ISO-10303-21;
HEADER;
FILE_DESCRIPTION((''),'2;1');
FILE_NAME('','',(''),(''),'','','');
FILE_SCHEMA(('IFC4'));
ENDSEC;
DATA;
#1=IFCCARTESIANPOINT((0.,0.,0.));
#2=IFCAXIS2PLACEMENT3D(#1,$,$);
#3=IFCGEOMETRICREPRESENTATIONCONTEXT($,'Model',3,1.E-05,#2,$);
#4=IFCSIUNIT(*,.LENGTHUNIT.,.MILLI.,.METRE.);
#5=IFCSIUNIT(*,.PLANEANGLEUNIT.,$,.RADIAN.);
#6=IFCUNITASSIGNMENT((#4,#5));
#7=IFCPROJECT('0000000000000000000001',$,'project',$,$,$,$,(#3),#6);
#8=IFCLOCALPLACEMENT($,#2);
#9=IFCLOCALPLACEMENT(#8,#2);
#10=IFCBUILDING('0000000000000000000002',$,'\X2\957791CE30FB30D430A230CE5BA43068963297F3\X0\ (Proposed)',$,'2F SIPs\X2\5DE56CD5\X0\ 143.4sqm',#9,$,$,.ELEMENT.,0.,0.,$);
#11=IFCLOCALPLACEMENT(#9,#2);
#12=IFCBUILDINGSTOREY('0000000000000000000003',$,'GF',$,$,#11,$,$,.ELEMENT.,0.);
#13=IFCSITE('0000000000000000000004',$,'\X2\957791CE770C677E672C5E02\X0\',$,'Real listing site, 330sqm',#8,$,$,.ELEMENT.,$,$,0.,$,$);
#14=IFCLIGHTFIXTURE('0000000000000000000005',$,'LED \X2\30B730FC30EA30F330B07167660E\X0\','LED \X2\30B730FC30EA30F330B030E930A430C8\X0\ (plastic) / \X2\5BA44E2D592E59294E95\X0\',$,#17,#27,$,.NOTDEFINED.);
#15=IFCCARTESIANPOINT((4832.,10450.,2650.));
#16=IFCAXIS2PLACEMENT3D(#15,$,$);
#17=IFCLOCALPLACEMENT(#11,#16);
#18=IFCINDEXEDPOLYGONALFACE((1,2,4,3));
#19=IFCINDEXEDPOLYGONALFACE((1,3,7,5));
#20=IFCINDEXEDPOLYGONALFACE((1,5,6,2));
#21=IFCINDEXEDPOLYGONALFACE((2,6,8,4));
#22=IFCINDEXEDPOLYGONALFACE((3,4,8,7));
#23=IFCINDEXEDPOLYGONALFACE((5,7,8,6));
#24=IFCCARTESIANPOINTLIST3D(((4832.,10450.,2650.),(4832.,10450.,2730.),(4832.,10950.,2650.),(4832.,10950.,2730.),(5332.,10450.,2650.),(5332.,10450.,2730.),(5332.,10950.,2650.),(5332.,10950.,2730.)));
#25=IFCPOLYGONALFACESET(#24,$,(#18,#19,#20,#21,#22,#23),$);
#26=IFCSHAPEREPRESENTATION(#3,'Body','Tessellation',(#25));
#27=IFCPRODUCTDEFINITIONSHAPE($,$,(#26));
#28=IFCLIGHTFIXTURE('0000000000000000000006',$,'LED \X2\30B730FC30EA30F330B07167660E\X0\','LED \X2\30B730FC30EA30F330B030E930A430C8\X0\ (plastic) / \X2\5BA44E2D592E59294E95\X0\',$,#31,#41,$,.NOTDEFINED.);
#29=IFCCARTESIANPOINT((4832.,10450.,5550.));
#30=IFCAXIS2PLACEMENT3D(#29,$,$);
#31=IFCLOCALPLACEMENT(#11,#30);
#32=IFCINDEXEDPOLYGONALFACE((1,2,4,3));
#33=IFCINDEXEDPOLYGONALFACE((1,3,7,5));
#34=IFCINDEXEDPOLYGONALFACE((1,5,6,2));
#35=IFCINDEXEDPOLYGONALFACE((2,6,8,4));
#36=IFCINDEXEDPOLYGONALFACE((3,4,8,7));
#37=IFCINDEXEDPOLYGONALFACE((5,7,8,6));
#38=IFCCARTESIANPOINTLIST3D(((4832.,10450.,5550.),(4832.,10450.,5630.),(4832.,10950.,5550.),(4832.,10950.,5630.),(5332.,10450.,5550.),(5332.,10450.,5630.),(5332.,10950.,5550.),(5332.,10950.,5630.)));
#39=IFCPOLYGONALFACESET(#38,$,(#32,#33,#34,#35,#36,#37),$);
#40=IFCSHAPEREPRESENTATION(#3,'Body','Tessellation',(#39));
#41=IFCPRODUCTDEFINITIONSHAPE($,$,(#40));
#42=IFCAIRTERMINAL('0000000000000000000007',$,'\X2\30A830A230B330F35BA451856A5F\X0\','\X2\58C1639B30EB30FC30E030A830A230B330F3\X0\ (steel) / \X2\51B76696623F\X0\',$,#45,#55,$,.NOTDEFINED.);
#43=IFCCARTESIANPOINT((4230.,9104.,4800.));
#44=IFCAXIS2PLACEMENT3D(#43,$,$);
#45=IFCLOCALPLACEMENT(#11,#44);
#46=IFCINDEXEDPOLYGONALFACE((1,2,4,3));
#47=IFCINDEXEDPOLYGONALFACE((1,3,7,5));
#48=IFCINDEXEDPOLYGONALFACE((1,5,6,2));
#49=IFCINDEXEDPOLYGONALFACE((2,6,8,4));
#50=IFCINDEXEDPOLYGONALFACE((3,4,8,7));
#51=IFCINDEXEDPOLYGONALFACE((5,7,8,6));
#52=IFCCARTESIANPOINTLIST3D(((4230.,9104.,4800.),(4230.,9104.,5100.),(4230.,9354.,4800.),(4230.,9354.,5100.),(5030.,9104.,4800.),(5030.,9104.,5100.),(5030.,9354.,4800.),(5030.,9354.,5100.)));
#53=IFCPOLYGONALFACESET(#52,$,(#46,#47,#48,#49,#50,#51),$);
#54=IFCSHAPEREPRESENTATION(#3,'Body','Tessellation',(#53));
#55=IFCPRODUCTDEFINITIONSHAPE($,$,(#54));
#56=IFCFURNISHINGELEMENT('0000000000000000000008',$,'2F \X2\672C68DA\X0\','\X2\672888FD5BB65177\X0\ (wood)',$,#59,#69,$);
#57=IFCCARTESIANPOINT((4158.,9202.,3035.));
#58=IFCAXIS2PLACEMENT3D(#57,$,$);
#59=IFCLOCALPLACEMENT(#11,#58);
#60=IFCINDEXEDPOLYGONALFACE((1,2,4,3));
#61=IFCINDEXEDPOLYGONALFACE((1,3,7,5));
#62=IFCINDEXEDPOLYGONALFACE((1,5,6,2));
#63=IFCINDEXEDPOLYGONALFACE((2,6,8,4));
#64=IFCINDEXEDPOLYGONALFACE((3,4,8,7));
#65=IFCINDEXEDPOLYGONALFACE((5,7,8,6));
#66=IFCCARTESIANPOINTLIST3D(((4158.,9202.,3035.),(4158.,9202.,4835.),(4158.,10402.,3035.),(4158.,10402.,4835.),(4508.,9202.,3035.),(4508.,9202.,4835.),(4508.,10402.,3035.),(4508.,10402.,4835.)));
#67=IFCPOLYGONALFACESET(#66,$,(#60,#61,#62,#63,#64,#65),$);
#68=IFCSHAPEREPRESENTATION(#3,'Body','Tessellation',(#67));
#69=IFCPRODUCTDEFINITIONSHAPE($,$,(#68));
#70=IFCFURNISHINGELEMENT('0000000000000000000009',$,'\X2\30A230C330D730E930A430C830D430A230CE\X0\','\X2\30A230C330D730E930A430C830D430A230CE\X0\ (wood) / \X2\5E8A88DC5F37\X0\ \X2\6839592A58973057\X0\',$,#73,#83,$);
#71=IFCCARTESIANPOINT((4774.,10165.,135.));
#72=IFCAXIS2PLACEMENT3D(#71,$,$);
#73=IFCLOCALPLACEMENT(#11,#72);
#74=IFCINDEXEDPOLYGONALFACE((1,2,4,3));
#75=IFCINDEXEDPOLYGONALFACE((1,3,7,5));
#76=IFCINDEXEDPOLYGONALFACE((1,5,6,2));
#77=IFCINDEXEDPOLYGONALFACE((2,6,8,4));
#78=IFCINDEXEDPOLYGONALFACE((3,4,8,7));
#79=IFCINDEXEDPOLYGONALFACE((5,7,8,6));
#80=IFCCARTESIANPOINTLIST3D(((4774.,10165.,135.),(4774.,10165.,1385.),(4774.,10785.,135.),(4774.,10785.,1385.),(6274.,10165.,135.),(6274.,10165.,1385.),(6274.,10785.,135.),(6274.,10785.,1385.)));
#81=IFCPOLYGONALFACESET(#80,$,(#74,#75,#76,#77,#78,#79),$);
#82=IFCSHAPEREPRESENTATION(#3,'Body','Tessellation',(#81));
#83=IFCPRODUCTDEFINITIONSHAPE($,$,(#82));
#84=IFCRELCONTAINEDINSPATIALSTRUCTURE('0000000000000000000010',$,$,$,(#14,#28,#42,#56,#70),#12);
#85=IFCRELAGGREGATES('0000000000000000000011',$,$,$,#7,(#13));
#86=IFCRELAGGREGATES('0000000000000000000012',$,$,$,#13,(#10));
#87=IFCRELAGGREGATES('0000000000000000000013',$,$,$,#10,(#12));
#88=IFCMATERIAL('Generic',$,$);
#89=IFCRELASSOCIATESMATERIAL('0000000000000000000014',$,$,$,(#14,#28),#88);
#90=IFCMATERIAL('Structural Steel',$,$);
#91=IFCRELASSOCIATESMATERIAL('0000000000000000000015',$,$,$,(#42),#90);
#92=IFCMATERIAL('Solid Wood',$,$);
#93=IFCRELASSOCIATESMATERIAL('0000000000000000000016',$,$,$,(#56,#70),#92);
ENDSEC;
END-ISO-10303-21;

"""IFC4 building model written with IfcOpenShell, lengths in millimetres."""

from ifc_helpers import new_model, si_unit, frame, frame_2d, origin, place, context, project, spatial, rectangle, extrude, material, element, save


model = new_model("IFC4")

# Units and contexts
model_context = context("Model", 3, precision=1e-05, world=origin())
ifc_project = project(units=[si_unit("LENGTHUNIT", "METRE", prefix="MILLI"), si_unit("PLANEANGLEUNIT", "RADIAN")], contexts=[model_context])

# Site, building, storey
site_placement = place(None, origin())
site = spatial("IfcSite", under=ifc_project, at=site_placement, Name="長野県松本市", ObjectType="Real listing site, 330sqm", CompositionType="ELEMENT", RefElevation=0.0)
building_placement = place(site_placement, origin())
building = spatial("IfcBuilding", under=site, at=building_placement, Name="長野・ピアノ室と防音 (Proposed)", ObjectType="2F SIPs工法 143.4sqm", CompositionType="ELEMENT", ElevationOfRefHeight=0.0, ElevationOfTerrain=0.0)
storey_placement = place(building_placement, origin())
storey = spatial("IfcBuildingStorey", under=building, at=storey_placement, Name="GF", CompositionType="ELEMENT", Elevation=0.0)

# Shared definitions
ifc_material_1 = material(Name="Solid Wood")

# Shared definitions
ifc_material_2 = material(Name="Structural Steel")

# Shared definitions
ifc_material_3 = material(Name="Generic")

# Light fixtures
light_fixture_1_placement = place(storey_placement, frame((4832.0, 10450.0, 2650.0)))
element("IfcLightFixture", 1, at=light_fixture_1_placement, inside=storey, material=ifc_material_3, Name="LED シーリング照明", Description="LED シーリングライト (plastic) / 室中央天井", PredefinedType="NOTDEFINED", context=model_context, shape_type="SweptSolid", body=[
    extrude(rectangle(XDim=500.0, YDim=500.0, at=frame_2d((250.0, 250.0))), frame((4832.0, 10450.0, 2650.0)), (0.0, 0.0, 1.0), 80.0),
])
light_fixture_2_placement = place(storey_placement, frame((4832.0, 10450.0, 5550.0)))
element("IfcLightFixture", 2, at=light_fixture_2_placement, inside=storey, material=ifc_material_3, Name="LED シーリング照明", Description="LED シーリングライト (plastic) / 室中央天井", PredefinedType="NOTDEFINED", context=model_context, shape_type="SweptSolid", body=[
    extrude(rectangle(XDim=500.0, YDim=500.0, at=frame_2d((250.0, 250.0))), frame((4832.0, 10450.0, 5550.0)), (0.0, 0.0, 1.0), 80.0),
])

# Air terminal
air_terminal_placement = place(storey_placement, frame((4230.0, 9104.0, 4800.0)))
element("IfcAirTerminal", 3, at=air_terminal_placement, inside=storey, material=ifc_material_2, Name="エアコン室内機", Description="壁掛ルームエアコン (steel) / 冷暖房", PredefinedType="NOTDEFINED", context=model_context, shape_type="SweptSolid", body=[
    extrude(rectangle(XDim=800.0, YDim=250.0, at=frame_2d((400.0, 125.0))), frame((4230.0, 9104.0, 4800.0)), (0.0, 0.0, 1.0), 300.0),
])

# Furnishing elements
furnishing_1_placement = place(storey_placement, frame((4158.0, 9202.0, 3035.0)))
element("IfcFurnishingElement", 4, at=furnishing_1_placement, inside=storey, material=ifc_material_1, Name="2F 本棚", Description="木製家具 (wood)", context=model_context, shape_type="SweptSolid", body=[
    extrude(rectangle(XDim=350.0, YDim=1200.0, at=frame_2d((175.0, 600.0))), frame((4158.0, 9202.0, 3035.0)), (0.0, 0.0, 1.0), 1800.0),
])
furnishing_2_placement = place(storey_placement, frame((4774.0, 10165.0, 135.0)))
element("IfcFurnishingElement", 5, at=furnishing_2_placement, inside=storey, material=ifc_material_1, Name="アップライトピアノ", Description="アップライトピアノ (wood) / 床補強 根太増し", context=model_context, shape_type="SweptSolid", body=[
    extrude(rectangle(XDim=1500.0, YDim=620.0, at=frame_2d((750.0, 310.0))), frame((4774.0, 10165.0, 135.0)), (0.0, 0.0, 1.0), 1250.0),
])

save(model, "model.ifc")
